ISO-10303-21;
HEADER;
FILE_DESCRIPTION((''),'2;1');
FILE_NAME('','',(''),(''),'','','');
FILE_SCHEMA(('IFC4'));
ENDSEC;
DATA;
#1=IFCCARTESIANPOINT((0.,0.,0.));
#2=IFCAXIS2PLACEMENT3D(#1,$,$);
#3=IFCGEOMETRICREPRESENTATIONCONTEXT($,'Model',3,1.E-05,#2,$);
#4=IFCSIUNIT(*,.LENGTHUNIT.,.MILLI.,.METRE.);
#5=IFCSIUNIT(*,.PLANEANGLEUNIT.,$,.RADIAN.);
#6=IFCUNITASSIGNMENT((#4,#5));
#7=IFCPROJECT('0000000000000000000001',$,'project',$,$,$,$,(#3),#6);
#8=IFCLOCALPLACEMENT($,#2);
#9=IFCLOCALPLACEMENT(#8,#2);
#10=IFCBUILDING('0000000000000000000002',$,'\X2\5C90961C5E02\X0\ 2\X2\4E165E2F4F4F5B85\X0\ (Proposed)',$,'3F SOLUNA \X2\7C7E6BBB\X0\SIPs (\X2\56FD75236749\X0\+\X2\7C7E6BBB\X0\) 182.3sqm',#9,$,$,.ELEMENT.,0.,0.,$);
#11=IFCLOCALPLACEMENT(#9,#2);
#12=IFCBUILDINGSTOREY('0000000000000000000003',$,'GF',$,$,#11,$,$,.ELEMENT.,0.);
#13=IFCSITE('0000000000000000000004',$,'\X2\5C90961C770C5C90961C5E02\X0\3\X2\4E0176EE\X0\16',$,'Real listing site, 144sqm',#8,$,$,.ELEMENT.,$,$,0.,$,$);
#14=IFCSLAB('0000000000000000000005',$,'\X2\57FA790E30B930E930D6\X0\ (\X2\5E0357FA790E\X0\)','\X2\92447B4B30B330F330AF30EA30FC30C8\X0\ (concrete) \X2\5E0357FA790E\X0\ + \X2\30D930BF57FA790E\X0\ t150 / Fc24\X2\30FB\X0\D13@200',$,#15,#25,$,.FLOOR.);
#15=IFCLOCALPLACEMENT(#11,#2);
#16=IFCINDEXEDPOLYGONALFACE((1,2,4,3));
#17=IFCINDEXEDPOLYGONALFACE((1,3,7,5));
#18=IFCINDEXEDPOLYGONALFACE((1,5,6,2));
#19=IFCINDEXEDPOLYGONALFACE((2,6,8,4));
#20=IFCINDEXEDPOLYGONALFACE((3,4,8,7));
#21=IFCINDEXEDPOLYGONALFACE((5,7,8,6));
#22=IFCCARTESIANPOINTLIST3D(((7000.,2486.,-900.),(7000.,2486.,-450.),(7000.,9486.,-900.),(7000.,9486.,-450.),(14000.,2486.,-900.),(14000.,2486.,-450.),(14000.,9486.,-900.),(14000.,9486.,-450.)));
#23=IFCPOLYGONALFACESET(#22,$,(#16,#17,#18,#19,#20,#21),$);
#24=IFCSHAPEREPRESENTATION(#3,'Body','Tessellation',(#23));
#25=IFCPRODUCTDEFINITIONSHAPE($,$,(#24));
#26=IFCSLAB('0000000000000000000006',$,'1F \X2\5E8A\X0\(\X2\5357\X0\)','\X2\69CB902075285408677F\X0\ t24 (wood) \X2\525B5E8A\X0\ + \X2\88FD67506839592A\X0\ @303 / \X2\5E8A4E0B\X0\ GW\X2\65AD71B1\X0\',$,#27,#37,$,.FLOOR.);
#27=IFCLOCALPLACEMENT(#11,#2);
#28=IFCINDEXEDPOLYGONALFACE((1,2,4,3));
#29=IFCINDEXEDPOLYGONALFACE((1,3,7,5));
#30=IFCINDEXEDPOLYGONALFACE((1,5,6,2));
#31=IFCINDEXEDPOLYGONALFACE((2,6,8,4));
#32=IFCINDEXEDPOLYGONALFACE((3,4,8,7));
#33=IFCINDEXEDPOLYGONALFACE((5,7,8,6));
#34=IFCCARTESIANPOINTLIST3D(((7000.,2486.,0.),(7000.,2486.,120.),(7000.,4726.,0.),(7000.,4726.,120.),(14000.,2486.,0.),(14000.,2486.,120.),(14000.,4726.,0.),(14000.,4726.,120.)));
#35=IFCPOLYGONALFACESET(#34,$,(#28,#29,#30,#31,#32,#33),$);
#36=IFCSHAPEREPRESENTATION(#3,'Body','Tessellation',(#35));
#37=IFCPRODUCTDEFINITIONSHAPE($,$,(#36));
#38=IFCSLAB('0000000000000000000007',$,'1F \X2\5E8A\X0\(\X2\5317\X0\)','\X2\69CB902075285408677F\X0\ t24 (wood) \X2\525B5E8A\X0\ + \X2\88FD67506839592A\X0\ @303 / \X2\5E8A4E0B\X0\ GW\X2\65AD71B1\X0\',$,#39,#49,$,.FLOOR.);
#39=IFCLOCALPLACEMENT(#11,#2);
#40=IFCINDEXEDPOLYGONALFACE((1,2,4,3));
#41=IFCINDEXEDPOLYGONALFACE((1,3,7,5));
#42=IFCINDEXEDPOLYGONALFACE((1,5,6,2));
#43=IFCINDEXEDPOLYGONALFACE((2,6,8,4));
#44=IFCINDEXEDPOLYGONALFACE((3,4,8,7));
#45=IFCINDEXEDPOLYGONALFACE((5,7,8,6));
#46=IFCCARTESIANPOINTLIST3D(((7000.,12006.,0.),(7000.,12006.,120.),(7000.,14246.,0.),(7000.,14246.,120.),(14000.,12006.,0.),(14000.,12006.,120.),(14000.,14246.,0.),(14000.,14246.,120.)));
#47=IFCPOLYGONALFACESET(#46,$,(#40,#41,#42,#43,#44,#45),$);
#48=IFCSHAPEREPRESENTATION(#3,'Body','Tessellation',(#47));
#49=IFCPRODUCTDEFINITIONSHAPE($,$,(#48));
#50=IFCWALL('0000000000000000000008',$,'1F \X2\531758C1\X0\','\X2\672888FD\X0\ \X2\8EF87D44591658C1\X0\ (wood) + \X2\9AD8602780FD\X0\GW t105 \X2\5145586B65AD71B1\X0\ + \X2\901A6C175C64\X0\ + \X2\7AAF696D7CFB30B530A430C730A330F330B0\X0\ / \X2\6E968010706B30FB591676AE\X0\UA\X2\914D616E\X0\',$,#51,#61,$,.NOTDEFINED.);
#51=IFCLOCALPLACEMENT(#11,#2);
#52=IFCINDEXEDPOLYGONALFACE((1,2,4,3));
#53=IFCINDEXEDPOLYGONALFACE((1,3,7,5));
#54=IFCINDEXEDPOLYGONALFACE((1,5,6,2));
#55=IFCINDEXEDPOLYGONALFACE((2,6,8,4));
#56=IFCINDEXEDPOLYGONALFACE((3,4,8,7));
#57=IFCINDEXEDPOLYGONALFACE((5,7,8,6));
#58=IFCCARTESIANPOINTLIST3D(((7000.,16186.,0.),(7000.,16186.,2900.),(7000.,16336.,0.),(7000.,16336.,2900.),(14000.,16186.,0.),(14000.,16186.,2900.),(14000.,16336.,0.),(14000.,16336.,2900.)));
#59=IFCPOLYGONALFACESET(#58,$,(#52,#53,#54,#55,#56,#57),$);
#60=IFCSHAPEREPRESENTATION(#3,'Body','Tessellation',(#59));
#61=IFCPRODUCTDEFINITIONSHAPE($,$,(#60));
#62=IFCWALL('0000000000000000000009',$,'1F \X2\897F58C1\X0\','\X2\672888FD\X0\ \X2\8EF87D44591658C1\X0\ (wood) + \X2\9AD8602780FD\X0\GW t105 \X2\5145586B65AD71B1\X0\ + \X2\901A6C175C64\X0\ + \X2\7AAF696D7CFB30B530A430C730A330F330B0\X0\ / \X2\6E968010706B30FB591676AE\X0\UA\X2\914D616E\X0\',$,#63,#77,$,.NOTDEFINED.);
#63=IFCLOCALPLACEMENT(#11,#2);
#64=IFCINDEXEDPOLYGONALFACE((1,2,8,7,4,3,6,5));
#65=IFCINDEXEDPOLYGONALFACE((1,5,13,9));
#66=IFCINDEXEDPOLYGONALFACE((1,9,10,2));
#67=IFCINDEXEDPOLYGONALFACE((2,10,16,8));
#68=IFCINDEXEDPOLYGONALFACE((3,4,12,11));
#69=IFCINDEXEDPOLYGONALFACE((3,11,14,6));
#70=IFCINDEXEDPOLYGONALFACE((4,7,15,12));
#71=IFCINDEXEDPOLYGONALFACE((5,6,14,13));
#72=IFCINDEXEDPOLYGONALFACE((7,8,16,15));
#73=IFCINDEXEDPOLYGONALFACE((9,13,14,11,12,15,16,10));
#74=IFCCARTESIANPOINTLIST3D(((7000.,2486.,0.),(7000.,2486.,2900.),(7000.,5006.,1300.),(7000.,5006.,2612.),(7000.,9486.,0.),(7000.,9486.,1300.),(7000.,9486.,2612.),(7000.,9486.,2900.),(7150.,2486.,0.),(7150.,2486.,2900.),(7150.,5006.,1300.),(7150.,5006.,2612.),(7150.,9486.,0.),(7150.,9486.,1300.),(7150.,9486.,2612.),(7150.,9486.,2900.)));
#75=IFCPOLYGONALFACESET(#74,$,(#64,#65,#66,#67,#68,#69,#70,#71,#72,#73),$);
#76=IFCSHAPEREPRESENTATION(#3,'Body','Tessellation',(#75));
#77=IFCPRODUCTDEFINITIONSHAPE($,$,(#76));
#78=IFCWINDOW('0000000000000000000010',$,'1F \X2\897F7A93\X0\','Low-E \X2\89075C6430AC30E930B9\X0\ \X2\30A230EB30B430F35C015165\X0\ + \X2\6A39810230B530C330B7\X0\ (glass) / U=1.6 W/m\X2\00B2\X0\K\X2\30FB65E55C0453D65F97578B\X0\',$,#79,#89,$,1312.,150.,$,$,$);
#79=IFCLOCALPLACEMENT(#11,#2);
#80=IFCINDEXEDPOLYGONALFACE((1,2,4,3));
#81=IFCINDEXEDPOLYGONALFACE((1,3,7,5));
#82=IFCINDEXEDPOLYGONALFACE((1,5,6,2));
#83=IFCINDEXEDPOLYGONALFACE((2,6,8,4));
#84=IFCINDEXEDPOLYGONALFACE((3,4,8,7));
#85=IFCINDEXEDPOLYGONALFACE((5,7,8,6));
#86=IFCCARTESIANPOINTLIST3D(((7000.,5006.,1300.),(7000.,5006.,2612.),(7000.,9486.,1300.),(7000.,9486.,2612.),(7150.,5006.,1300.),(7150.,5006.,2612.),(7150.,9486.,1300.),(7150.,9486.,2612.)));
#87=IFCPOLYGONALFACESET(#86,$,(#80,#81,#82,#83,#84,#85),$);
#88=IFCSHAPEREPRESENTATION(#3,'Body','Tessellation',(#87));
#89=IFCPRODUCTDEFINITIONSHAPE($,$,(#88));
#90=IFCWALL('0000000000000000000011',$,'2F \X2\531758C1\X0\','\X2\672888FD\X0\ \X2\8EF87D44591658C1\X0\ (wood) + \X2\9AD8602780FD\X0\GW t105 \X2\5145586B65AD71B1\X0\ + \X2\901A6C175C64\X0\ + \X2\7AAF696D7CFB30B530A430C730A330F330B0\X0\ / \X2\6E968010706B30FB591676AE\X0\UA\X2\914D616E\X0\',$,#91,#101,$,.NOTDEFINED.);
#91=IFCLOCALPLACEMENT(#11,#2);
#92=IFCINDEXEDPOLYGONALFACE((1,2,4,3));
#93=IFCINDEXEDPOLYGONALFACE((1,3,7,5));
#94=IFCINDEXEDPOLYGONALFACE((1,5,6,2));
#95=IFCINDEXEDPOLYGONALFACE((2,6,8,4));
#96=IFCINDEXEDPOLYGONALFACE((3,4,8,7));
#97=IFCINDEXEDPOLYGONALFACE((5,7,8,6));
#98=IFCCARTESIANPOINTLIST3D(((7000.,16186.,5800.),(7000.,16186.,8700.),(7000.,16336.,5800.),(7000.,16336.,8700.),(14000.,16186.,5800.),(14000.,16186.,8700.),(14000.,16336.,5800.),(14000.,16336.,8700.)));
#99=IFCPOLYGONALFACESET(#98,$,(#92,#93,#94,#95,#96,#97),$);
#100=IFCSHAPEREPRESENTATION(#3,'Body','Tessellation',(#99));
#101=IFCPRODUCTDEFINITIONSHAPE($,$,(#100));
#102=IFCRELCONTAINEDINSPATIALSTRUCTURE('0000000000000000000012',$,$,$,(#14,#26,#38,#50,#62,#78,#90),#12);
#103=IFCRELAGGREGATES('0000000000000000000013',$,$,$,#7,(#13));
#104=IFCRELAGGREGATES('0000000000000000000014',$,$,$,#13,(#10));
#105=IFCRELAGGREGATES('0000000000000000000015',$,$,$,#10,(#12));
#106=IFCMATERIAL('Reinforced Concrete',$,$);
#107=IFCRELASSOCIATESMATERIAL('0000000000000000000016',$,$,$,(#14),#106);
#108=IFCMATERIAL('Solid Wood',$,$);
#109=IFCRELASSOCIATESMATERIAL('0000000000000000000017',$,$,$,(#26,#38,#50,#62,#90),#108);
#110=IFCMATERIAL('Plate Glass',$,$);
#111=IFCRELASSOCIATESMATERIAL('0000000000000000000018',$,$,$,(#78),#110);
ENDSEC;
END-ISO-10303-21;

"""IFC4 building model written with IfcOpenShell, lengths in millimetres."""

from ifc_helpers import new_model, si_unit, frame, frame_2d, origin, place, context, project, spatial, rectangle, extrude, material, element, fill, save


model = new_model("IFC4")

# Units and contexts
model_context = context("Model", 3, precision=1e-05, world=origin())
ifc_project = project(units=[si_unit("LENGTHUNIT", "METRE", prefix="MILLI"), si_unit("PLANEANGLEUNIT", "RADIAN")], contexts=[model_context])

# Site, building, storey
site_placement = place(None, origin())
site = spatial("IfcSite", under=ifc_project, at=site_placement, Name="岐阜県岐阜市3丁目16", ObjectType="Real listing site, 144sqm", CompositionType="ELEMENT", RefElevation=0.0)
building_placement = place(site_placement, origin())
building = spatial("IfcBuilding", under=site, at=building_placement, Name="岐阜市 2世帯住宅 (Proposed)", ObjectType="3F SOLUNA 籾殻SIPs (国産杉+籾殻) 182.3sqm", CompositionType="ELEMENT", ElevationOfRefHeight=0.0, ElevationOfTerrain=0.0)
storey_placement = place(building_placement, origin())
storey = spatial("IfcBuildingStorey", under=building, at=storey_placement, Name="GF", CompositionType="ELEMENT", Elevation=0.0)

# Slabs
ifc_material_1 = material(Name="Reinforced Concrete")
slab_1_placement = place(storey_placement, frame((3500.0, 1243.0, -450.0)))
element("IfcSlab", 1, at=slab_1_placement, inside=storey, material=ifc_material_1, Name="基礎スラブ (布基礎)", Description="鉄筋コンクリート (concrete) 布基礎 + ベタ基礎 t150 / Fc24・D13@200", PredefinedType="FLOOR", context=model_context, shape_type="SweptSolid", body=[
    extrude(rectangle(XDim=7000.0, YDim=7000.0, at=frame_2d((3500.0, 3500.0))), frame((3500.0, 1243.0, -450.0)), (0.0, 0.0, 1.0), 450.0),
])
ifc_material_2 = material(Name="Solid Wood")
slab_2_placement = place(storey_placement, frame((3500.0, 1243.0, 0.0)))
element("IfcSlab", 2, at=slab_2_placement, inside=storey, material=ifc_material_2, Name="1F 床(南)", Description="構造用合板 t24 (wood) 剛床 + 製材根太 @303 / 床下 GW断熱", PredefinedType="FLOOR", context=model_context, shape_type="SweptSolid", body=[
    extrude(rectangle(XDim=7000.0, YDim=2240.0, at=frame_2d((3500.0, 1120.0))), frame((3500.0, 1243.0, 0.0)), (0.0, 0.0, 1.0), 120.0),
])
slab_3_placement = place(storey_placement, frame((3500.0, 6003.0, 0.0)))
element("IfcSlab", 3, at=slab_3_placement, inside=storey, material=ifc_material_2, Name="1F 床(北)", Description="構造用合板 t24 (wood) 剛床 + 製材根太 @303 / 床下 GW断熱", PredefinedType="FLOOR", context=model_context, shape_type="SweptSolid", body=[
    extrude(rectangle(XDim=7000.0, YDim=2240.0, at=frame_2d((3500.0, 1120.0))), frame((3500.0, 6003.0, 0.0)), (0.0, 0.0, 1.0), 120.0),
])

# Shared definitions
ifc_material_3 = material(Name="Plate Glass")

# Wall
wall_1_placement = place(storey_placement, frame((3500.0, 8093.0, 0.0)))
element("IfcWall", 4, at=wall_1_placement, inside=storey, material=ifc_material_2, Name="1F 北壁", Description="木製 軸組外壁 (wood) + 高性能GW t105 充填断熱 + 通気層 + 窯業系サイディング / 準耐火・外皮UA配慮", PredefinedType="NOTDEFINED", context=model_context, shape_type="SweptSolid", body=[
    extrude(rectangle(XDim=7000.0, YDim=150.0, at=frame_2d((3500.0, 75.0))), frame((3500.0, 8093.0, 0.0)), (0.0, 0.0, 1.0), 2900.0),
])

# Wall, opening, window
wall_2_placement = place(storey_placement, frame((3500.0, 1243.0, 0.0)))
wall_2 = element("IfcWall", 5, at=wall_2_placement, inside=storey, material=ifc_material_2, Name="1F 西壁", Description="木製 軸組外壁 (wood) + 高性能GW t105 充填断熱 + 通気層 + 窯業系サイディング / 準耐火・外皮UA配慮", PredefinedType="NOTDEFINED", context=model_context, shape_type="SweptSolid", body=[
    extrude(rectangle(XDim=150.0, YDim=7000.0, at=frame_2d((75.0, 3500.0))), frame((3500.0, 1243.0, 0.0)), (0.0, 0.0, 1.0), 2900.0),
])
opening_1_placement = place(storey_placement, frame((3500.0, 2503.0, 650.0)))
opening_1 = element("IfcOpeningElement", 6, at=opening_1_placement, cuts=wall_2, PredefinedType="NOTDEFINED", context=model_context, shape_type="SweptSolid", body=[
    extrude(rectangle(XDim=150.0, YDim=4480.0, at=frame_2d((75.0, 2240.0))), frame((3500.0, 2503.0, 650.0)), (0.0, 0.0, 1.0), 1312.0),
])
window_1_placement = place(storey_placement, frame((3500.0, 2503.0, 650.0)))
window_1 = element("IfcWindow", 7, at=window_1_placement, inside=storey, material=ifc_material_3, Name="1F 西窓", Description="Low-E 複層ガラス アルゴン封入 + 樹脂サッシ (glass) / U=1.6 W/m²K・日射取得型", OverallHeight=1312.0, OverallWidth=150.0, context=model_context, shape_type="SweptSolid", body=[
    extrude(rectangle(XDim=150.0, YDim=4480.0, at=frame_2d((75.0, 2240.0))), frame((3500.0, 2503.0, 650.0)), (0.0, 0.0, 1.0), 1312.0),
])
fill(opening_1, window_1)

# Wall
wall_3_placement = place(storey_placement, frame((3500.0, 8093.0, 2900.0)))
element("IfcWall", 8, at=wall_3_placement, inside=storey, material=ifc_material_2, Name="2F 北壁", Description="木製 軸組外壁 (wood) + 高性能GW t105 充填断熱 + 通気層 + 窯業系サイディング / 準耐火・外皮UA配慮", PredefinedType="NOTDEFINED", context=model_context, shape_type="SweptSolid", body=[
    extrude(rectangle(XDim=7000.0, YDim=150.0, at=frame_2d((3500.0, 75.0))), frame((3500.0, 8093.0, 2900.0)), (0.0, 0.0, 1.0), 2900.0),
])

save(model, "model.ifc")
